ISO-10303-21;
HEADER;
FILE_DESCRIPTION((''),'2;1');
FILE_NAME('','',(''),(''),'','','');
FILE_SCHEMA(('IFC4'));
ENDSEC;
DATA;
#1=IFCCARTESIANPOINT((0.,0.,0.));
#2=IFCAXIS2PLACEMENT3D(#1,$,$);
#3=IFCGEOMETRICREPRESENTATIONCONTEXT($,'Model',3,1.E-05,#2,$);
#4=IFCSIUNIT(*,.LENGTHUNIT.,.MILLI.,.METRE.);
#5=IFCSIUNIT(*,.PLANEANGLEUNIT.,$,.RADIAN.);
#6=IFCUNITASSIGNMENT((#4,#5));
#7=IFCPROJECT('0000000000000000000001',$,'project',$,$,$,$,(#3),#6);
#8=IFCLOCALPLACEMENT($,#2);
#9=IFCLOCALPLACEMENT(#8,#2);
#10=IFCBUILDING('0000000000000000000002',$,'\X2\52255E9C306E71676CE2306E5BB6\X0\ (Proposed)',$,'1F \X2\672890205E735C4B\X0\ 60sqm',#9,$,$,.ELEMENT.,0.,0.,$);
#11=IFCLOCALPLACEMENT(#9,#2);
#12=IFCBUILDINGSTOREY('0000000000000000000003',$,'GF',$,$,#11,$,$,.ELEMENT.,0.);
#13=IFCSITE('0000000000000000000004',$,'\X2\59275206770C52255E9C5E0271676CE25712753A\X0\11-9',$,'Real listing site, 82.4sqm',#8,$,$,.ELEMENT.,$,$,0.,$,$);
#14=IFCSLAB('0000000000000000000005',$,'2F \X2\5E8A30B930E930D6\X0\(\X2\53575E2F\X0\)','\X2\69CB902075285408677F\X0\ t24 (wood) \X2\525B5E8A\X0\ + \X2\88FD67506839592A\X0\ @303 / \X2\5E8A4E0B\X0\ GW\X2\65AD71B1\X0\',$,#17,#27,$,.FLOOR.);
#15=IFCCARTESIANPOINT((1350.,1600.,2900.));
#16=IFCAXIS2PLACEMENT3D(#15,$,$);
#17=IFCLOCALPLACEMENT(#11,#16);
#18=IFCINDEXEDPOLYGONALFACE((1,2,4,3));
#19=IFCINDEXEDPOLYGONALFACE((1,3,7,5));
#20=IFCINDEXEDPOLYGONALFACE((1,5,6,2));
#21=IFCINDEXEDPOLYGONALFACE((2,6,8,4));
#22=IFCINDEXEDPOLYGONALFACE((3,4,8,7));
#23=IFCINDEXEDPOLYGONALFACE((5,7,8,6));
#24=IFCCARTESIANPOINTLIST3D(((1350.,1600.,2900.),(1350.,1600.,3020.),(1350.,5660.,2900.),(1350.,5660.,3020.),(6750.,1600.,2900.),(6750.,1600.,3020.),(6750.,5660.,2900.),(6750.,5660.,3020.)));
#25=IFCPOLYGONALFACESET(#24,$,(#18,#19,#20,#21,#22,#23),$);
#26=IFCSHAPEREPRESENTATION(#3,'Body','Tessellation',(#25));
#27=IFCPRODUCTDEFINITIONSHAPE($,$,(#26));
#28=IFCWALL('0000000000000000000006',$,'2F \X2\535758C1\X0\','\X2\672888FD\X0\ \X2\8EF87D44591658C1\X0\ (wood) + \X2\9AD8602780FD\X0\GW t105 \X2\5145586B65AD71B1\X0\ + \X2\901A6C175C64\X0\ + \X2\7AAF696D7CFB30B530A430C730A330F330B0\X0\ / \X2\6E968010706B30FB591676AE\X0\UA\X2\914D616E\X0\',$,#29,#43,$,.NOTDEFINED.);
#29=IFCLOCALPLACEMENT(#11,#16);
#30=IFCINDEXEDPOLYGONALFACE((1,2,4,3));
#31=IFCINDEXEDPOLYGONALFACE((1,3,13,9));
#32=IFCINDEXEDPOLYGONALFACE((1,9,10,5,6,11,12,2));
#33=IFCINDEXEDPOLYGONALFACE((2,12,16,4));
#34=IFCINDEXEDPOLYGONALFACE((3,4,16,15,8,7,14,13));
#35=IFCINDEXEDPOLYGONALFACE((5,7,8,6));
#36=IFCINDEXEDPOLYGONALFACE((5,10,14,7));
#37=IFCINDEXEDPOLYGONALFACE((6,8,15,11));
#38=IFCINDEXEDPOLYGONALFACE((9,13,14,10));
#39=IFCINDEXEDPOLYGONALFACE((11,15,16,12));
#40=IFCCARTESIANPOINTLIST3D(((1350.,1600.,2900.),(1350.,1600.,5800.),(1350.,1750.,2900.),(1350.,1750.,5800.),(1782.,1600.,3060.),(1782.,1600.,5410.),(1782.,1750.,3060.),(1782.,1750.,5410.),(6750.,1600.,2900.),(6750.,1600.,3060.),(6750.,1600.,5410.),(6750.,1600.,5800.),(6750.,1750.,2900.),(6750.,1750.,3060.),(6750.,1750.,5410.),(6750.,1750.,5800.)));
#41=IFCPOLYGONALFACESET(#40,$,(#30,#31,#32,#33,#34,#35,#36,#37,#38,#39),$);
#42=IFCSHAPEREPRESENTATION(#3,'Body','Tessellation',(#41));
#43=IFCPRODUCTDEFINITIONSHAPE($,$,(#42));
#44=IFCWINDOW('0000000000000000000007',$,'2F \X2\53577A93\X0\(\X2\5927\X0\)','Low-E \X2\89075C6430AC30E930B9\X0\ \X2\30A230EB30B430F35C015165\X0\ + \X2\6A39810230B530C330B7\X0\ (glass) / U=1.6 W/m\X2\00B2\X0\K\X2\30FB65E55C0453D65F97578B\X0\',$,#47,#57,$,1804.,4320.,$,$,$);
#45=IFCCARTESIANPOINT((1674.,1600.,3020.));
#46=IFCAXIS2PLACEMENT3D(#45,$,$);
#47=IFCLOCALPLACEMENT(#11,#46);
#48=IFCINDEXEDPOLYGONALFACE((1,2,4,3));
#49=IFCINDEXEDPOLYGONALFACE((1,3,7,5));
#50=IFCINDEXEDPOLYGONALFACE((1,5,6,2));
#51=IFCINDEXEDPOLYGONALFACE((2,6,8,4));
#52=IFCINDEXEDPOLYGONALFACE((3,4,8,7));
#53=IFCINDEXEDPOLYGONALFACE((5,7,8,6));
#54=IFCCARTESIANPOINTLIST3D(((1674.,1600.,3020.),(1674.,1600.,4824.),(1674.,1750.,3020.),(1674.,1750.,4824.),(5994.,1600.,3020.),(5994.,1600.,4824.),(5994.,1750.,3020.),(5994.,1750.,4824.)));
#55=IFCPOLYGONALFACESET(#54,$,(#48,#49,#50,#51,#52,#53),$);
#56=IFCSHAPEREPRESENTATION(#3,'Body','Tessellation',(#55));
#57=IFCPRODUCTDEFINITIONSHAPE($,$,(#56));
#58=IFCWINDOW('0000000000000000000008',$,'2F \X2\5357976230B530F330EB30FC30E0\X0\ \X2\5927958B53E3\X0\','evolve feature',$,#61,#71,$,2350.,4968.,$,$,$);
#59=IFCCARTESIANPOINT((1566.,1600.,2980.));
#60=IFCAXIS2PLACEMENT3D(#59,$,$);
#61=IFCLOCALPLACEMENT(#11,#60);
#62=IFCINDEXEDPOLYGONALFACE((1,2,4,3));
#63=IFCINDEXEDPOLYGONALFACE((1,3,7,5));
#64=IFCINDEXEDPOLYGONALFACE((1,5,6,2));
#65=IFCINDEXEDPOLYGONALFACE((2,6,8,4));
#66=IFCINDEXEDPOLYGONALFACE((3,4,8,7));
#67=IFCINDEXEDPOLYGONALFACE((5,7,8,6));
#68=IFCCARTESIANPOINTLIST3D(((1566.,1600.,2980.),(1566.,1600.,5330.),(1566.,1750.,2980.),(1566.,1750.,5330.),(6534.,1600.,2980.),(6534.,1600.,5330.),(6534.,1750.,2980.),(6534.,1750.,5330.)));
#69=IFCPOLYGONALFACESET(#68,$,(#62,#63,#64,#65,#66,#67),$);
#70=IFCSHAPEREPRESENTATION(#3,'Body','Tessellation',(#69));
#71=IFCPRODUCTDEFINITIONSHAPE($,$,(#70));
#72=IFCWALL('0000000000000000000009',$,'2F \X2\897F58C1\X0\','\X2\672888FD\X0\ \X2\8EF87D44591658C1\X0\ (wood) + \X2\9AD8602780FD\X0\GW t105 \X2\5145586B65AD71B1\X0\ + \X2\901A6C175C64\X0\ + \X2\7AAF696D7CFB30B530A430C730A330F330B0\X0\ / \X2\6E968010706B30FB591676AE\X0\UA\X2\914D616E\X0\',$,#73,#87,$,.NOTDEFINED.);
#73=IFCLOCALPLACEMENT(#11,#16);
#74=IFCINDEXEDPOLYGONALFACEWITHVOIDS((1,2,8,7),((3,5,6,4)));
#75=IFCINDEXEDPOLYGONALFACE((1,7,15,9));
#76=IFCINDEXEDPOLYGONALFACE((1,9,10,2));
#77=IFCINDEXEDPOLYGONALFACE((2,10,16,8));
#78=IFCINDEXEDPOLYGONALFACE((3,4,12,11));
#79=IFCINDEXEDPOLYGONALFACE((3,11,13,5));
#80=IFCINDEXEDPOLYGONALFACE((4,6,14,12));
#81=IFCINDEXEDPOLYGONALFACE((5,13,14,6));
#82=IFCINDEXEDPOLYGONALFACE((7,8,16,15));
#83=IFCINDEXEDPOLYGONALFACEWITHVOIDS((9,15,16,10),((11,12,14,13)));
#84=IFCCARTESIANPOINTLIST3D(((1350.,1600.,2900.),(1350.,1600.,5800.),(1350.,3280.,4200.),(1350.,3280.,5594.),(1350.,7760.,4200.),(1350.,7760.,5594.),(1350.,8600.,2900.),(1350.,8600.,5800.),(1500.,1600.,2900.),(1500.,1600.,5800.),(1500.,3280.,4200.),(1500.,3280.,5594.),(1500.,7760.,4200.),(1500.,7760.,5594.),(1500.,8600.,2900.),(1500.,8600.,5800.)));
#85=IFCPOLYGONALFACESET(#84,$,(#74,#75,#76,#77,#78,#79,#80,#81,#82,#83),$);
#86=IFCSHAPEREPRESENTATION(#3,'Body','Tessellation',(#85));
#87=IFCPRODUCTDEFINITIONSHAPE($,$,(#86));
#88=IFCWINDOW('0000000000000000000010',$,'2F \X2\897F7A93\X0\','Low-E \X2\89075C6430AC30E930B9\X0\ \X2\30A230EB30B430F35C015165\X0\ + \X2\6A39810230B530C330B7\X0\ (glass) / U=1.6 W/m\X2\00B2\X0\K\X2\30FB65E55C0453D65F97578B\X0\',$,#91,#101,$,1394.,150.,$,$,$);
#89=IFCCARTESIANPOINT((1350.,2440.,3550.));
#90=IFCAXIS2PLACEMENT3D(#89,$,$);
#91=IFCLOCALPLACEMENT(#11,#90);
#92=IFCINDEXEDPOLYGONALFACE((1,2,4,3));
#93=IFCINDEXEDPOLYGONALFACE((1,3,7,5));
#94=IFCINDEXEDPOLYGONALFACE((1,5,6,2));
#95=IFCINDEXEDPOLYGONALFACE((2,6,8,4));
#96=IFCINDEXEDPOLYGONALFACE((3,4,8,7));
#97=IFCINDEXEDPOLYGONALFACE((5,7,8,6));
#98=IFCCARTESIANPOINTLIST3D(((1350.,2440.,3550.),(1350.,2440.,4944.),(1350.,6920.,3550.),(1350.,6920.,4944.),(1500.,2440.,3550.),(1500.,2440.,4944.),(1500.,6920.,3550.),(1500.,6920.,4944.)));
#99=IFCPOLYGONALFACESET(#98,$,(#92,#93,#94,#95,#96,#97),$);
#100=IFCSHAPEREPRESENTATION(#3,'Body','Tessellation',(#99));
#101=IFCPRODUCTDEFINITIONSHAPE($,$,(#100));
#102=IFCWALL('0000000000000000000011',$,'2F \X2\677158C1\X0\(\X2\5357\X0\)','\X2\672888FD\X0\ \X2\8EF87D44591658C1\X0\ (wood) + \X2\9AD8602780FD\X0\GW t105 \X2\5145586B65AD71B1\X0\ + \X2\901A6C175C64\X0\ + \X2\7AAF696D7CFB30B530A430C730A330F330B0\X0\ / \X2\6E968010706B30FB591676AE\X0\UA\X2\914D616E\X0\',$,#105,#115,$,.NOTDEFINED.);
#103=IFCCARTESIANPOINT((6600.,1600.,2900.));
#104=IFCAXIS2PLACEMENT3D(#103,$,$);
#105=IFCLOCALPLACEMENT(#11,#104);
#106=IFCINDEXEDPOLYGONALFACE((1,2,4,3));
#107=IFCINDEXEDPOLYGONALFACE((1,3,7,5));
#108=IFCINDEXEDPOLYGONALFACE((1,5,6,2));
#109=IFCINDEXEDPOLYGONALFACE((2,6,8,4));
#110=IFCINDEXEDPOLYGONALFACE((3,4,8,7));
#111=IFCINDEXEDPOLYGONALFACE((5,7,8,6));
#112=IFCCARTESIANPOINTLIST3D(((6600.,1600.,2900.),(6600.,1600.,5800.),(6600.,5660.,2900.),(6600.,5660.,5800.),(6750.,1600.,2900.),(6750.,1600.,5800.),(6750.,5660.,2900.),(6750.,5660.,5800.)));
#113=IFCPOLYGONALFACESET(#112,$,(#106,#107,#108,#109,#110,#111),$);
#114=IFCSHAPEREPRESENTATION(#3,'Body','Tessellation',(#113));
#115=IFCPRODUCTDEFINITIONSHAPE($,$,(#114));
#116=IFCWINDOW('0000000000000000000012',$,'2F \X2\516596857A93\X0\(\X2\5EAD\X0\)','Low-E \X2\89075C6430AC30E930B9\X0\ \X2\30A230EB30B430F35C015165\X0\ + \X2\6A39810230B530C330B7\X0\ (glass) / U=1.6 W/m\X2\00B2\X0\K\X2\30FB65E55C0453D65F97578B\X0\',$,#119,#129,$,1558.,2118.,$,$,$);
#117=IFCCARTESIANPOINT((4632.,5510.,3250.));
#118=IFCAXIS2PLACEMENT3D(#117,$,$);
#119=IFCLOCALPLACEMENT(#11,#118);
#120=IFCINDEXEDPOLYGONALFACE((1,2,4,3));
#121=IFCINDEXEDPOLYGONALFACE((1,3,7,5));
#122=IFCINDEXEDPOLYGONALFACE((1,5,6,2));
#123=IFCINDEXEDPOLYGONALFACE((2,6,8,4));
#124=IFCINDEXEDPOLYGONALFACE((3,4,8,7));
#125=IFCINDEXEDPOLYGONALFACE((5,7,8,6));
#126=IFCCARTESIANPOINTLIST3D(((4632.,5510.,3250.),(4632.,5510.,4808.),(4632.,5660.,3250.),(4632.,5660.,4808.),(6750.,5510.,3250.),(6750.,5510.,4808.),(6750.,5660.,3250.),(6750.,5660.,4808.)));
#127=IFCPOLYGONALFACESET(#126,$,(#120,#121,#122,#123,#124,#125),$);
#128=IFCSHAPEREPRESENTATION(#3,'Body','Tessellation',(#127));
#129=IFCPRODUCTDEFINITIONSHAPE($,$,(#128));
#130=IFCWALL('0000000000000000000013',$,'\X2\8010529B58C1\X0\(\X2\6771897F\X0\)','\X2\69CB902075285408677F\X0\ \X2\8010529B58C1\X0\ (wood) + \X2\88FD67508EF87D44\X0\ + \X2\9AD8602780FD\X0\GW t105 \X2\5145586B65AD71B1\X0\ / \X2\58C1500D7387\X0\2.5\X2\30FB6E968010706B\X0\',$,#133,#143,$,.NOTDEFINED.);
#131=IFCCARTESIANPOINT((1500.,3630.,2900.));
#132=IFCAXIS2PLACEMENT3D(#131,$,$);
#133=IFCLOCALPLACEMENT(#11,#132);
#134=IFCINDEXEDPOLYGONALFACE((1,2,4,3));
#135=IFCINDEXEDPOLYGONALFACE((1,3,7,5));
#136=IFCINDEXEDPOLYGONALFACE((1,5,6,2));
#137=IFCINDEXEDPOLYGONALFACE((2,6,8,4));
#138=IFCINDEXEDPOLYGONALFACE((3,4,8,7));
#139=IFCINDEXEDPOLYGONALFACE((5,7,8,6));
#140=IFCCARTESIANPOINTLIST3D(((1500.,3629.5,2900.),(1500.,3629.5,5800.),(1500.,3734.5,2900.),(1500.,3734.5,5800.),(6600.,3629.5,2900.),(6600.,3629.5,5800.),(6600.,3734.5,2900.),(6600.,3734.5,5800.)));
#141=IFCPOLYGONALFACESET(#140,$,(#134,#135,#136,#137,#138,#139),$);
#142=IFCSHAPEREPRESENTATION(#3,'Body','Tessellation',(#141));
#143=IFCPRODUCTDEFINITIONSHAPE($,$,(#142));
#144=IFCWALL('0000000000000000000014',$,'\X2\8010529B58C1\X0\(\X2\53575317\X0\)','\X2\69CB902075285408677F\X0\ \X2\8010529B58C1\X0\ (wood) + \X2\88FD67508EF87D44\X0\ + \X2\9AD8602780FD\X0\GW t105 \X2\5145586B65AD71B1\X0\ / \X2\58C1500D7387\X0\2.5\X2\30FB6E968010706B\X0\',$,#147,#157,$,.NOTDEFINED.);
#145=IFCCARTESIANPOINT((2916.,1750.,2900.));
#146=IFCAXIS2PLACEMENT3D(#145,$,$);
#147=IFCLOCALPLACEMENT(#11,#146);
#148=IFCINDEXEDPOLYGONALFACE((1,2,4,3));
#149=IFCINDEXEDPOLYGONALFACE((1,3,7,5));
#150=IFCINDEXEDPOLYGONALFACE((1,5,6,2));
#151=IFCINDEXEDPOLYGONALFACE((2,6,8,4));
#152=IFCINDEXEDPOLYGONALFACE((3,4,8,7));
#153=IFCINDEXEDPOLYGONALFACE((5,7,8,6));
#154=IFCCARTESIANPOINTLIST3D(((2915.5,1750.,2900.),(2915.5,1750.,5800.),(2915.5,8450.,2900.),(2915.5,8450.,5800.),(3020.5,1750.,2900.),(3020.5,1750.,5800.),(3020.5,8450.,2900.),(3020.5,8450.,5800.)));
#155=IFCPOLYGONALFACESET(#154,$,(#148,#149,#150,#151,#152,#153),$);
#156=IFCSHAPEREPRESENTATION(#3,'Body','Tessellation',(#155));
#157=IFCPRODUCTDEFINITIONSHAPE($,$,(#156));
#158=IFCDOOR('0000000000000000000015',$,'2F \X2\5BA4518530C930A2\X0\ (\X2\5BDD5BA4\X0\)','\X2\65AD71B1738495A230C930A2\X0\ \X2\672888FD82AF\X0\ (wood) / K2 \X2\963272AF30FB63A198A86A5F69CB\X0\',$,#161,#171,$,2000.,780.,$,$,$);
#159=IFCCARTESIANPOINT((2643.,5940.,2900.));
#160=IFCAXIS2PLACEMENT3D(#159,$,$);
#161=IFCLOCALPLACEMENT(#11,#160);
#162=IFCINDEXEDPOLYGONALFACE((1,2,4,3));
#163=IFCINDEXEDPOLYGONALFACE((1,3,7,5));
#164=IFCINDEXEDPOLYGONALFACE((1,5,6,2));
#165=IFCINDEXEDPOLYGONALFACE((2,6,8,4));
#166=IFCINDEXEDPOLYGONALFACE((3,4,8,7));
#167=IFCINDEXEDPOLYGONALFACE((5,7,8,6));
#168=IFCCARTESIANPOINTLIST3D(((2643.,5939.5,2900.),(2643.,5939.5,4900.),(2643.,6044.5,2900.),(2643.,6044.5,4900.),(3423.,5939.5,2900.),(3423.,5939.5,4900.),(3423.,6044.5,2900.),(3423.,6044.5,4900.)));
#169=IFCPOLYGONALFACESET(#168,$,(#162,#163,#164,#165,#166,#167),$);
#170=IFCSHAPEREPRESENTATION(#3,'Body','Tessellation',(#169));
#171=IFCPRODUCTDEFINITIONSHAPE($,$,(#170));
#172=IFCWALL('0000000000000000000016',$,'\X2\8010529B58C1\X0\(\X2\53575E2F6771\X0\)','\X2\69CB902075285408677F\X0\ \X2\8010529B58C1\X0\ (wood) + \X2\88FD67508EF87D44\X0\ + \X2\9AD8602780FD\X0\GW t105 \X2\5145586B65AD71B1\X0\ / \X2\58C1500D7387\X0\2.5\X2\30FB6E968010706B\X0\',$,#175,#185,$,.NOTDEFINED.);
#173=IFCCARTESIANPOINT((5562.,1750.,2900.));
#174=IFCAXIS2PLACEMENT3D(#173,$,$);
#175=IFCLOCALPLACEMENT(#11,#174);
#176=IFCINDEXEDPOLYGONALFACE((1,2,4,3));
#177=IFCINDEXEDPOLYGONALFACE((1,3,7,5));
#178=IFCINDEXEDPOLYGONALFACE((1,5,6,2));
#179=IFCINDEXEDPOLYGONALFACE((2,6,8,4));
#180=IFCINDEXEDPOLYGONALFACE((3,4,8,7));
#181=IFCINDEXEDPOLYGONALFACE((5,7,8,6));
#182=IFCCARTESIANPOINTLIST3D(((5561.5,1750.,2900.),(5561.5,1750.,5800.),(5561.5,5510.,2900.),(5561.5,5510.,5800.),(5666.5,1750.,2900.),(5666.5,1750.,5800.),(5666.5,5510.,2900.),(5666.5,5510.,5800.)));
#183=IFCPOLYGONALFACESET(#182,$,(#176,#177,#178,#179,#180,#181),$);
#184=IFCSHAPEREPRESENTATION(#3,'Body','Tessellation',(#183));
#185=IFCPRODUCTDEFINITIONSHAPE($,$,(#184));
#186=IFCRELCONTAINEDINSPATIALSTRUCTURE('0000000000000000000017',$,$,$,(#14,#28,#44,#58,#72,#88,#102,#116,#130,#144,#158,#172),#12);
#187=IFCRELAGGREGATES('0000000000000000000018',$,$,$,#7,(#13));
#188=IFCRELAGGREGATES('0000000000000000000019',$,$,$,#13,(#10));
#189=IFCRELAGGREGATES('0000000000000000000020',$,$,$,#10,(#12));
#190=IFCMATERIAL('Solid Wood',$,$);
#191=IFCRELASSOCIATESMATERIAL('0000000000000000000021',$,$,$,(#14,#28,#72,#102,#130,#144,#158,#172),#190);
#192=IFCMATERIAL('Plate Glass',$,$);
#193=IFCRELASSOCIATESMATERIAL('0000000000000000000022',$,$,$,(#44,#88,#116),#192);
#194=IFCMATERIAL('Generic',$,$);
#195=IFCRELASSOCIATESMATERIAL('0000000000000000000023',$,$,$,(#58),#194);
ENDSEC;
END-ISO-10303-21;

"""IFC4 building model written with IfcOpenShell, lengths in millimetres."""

from ifc_helpers import new_model, si_unit, frame, frame_2d, origin, place, context, project, spatial, rectangle, extrude, material, element, fill, save


model = new_model("IFC4")

# Units and contexts
model_context = context("Model", 3, precision=1e-05, world=origin())
ifc_project = project(units=[si_unit("LENGTHUNIT", "METRE", prefix="MILLI"), si_unit("PLANEANGLEUNIT", "RADIAN")], contexts=[model_context])

# Site, building, storey
site_placement = place(None, origin())
site = spatial("IfcSite", under=ifc_project, at=site_placement, Name="大分県別府市照波園町11-9", ObjectType="Real listing site, 82.4sqm", CompositionType="ELEMENT", RefElevation=0.0)
building_placement = place(site_placement, origin())
building = spatial("IfcBuilding", under=site, at=building_placement, Name="別府の照波の家 (Proposed)", ObjectType="1F 木造平屋 60sqm", CompositionType="ELEMENT", ElevationOfRefHeight=0.0, ElevationOfTerrain=0.0)
storey_placement = place(building_placement, origin())
storey = spatial("IfcBuildingStorey", under=building, at=storey_placement, Name="GF", CompositionType="ELEMENT", Elevation=0.0)

# Slab
ifc_material_1 = material(Name="Solid Wood")
slab_placement = place(storey_placement, frame((1350.0, 1600.0, 2900.0)))
element("IfcSlab", 1, at=slab_placement, inside=storey, material=ifc_material_1, Name="2F 床スラブ(南帯)", Description="構造用合板 t24 (wood) 剛床 + 製材根太 @303 / 床下 GW断熱", PredefinedType="FLOOR", context=model_context, shape_type="SweptSolid", body=[
    extrude(rectangle(XDim=5400.0, YDim=4060.0, at=frame_2d((2700.0, 2030.0))), frame((1350.0, 1600.0, 2900.0)), (0.0, 0.0, 1.0), 120.0),
])

# Wall, openings, windows
wall_1_placement = place(storey_placement, frame((1350.0, 1600.0, 2900.0)))
wall_1 = element("IfcWall", 2, at=wall_1_placement, inside=storey, material=ifc_material_1, Name="2F 南壁", Description="木製 軸組外壁 (wood) + 高性能GW t105 充填断熱 + 通気層 + 窯業系サイディング / 準耐火・外皮UA配慮", PredefinedType="NOTDEFINED", context=model_context, shape_type="SweptSolid", body=[
    extrude(rectangle(XDim=5400.0, YDim=150.0, at=frame_2d((2700.0, 75.0))), frame((1350.0, 1600.0, 2900.0)), (0.0, 0.0, 1.0), 2900.0),
])
opening_1_placement = place(storey_placement, frame((1674.0, 1600.0, 3020.0)))
opening_1 = element("IfcOpeningElement", 3, at=opening_1_placement, cuts=wall_1, PredefinedType="NOTDEFINED", context=model_context, shape_type="SweptSolid", body=[
    extrude(rectangle(XDim=4320.0, YDim=150.0, at=frame_2d((2160.0, 75.0))), frame((1674.0, 1600.0, 3020.0)), (0.0, 0.0, 1.0), 1804.0),
])
opening_2_placement = place(storey_placement, frame((1566.0, 1600.0, 2980.0)))
opening_2 = element("IfcOpeningElement", 4, at=opening_2_placement, cuts=wall_1, PredefinedType="NOTDEFINED", context=model_context, shape_type="SweptSolid", body=[
    extrude(rectangle(XDim=4968.0, YDim=150.0, at=frame_2d((2484.0, 75.0))), frame((1566.0, 1600.0, 2980.0)), (0.0, 0.0, 1.0), 2350.0),
])
ifc_material_2 = material(Name="Plate Glass")
window_1_placement = place(storey_placement, frame((1674.0, 1600.0, 3020.0)))
window_1 = element("IfcWindow", 5, at=window_1_placement, inside=storey, material=ifc_material_2, Name="2F 南窓(大)", Description="Low-E 複層ガラス アルゴン封入 + 樹脂サッシ (glass) / U=1.6 W/m²K・日射取得型", OverallHeight=1804.0, OverallWidth=4320.0, context=model_context, shape_type="SweptSolid", body=[
    extrude(rectangle(XDim=4320.0, YDim=150.0, at=frame_2d((2160.0, 75.0))), frame((1674.0, 1600.0, 3020.0)), (0.0, 0.0, 1.0), 1804.0),
])
fill(opening_1, window_1)
ifc_material_3 = material(Name="Generic")
window_2_placement = place(storey_placement, frame((1566.0, 1600.0, 2980.0)))
window_2 = element("IfcWindow", 6, at=window_2_placement, inside=storey, material=ifc_material_3, Name="2F 南面サンルーム 大開口", Description="evolve feature", OverallHeight=2350.0, OverallWidth=4968.0, context=model_context, shape_type="SweptSolid", body=[
    extrude(rectangle(XDim=4968.0, YDim=150.0, at=frame_2d((2484.0, 75.0))), frame((1566.0, 1600.0, 2980.0)), (0.0, 0.0, 1.0), 2350.0),
])
fill(opening_2, window_2)

# Walls, openings, windows
wall_2_placement = place(storey_placement, frame((1350.0, 1600.0, 2900.0)))
wall_2 = element("IfcWall", 7, at=wall_2_placement, inside=storey, material=ifc_material_1, Name="2F 西壁", Description="木製 軸組外壁 (wood) + 高性能GW t105 充填断熱 + 通気層 + 窯業系サイディング / 準耐火・外皮UA配慮", PredefinedType="NOTDEFINED", context=model_context, shape_type="SweptSolid", body=[
    extrude(rectangle(XDim=150.0, YDim=7000.0, at=frame_2d((75.0, 3500.0))), frame((1350.0, 1600.0, 2900.0)), (0.0, 0.0, 1.0), 2900.0),
])
opening_3_placement = place(storey_placement, frame((1350.0, 2440.0, 3550.0)))
opening_3 = element("IfcOpeningElement", 8, at=opening_3_placement, cuts=wall_2, PredefinedType="NOTDEFINED", context=model_context, shape_type="SweptSolid", body=[
    extrude(rectangle(XDim=150.0, YDim=4480.0, at=frame_2d((75.0, 2240.0))), frame((1350.0, 2440.0, 3550.0)), (0.0, 0.0, 1.0), 1394.0),
])
window_3_placement = place(storey_placement, frame((1350.0, 2440.0, 3550.0)))
window_3 = element("IfcWindow", 9, at=window_3_placement, inside=storey, material=ifc_material_2, Name="2F 西窓", Description="Low-E 複層ガラス アルゴン封入 + 樹脂サッシ (glass) / U=1.6 W/m²K・日射取得型", OverallHeight=1394.0, OverallWidth=150.0, context=model_context, shape_type="SweptSolid", body=[
    extrude(rectangle(XDim=150.0, YDim=4480.0, at=frame_2d((75.0, 2240.0))), frame((1350.0, 2440.0, 3550.0)), (0.0, 0.0, 1.0), 1394.0),
])
fill(opening_3, window_3)
wall_3_placement = place(storey_placement, frame((6600.0, 1600.0, 2900.0)))
wall_3 = element("IfcWall", 10, at=wall_3_placement, inside=storey, material=ifc_material_1, Name="2F 東壁(南)", Description="木製 軸組外壁 (wood) + 高性能GW t105 充填断熱 + 通気層 + 窯業系サイディング / 準耐火・外皮UA配慮", PredefinedType="NOTDEFINED", context=model_context, shape_type="SweptSolid", body=[
    extrude(rectangle(XDim=150.0, YDim=4060.0, at=frame_2d((75.0, 2030.0))), frame((6600.0, 1600.0, 2900.0)), (0.0, 0.0, 1.0), 2900.0),
])
opening_4_placement = place(storey_placement, frame((4632.0, 5510.0, 3250.0)))
opening_4 = element("IfcOpeningElement", 11, at=opening_4_placement, cuts=wall_3, PredefinedType="NOTDEFINED", context=model_context, shape_type="SweptSolid", body=[
    extrude(rectangle(XDim=2118.0, YDim=150.0, at=frame_2d((1059.0, 75.0))), frame((4632.0, 5510.0, 3250.0)), (0.0, 0.0, 1.0), 1558.0),
])
window_4_placement = place(storey_placement, frame((4632.0, 5510.0, 3250.0)))
window_4 = element("IfcWindow", 12, at=window_4_placement, inside=storey, material=ifc_material_2, Name="2F 入隅窓(庭)", Description="Low-E 複層ガラス アルゴン封入 + 樹脂サッシ (glass) / U=1.6 W/m²K・日射取得型", OverallHeight=1558.0, OverallWidth=2118.0, context=model_context, shape_type="SweptSolid", body=[
    extrude(rectangle(XDim=2118.0, YDim=150.0, at=frame_2d((1059.0, 75.0))), frame((4632.0, 5510.0, 3250.0)), (0.0, 0.0, 1.0), 1558.0),
])
fill(opening_4, window_4)

# Wall
wall_4_placement = place(storey_placement, frame((1500.0, 3630.0, 2900.0)))
element("IfcWall", 13, at=wall_4_placement, inside=storey, material=ifc_material_1, Name="耐力壁(東西)", Description="構造用合板 耐力壁 (wood) + 製材軸組 + 高性能GW t105 充填断熱 / 壁倍率2.5・準耐火", PredefinedType="NOTDEFINED", context=model_context, shape_type="SweptSolid", body=[
    extrude(rectangle(XDim=5100.0, YDim=105.0, at=frame_2d((2550.0, 52.0))), frame((1500.0, 3630.0, 2900.0)), (0.0, 0.0, 1.0), 2900.0),
])

# Wall, opening, door
wall_5_placement = place(storey_placement, frame((2916.0, 1750.0, 2900.0)))
wall_5 = element("IfcWall", 14, at=wall_5_placement, inside=storey, material=ifc_material_1, Name="耐力壁(南北)", Description="構造用合板 耐力壁 (wood) + 製材軸組 + 高性能GW t105 充填断熱 / 壁倍率2.5・準耐火", PredefinedType="NOTDEFINED", context=model_context, shape_type="SweptSolid", body=[
    extrude(rectangle(XDim=105.0, YDim=6700.0, at=frame_2d((52.0, 3350.0))), frame((2916.0, 1750.0, 2900.0)), (0.0, 0.0, 1.0), 2900.0),
])
opening_5_placement = place(storey_placement, frame((2643.0, 5940.0, 2900.0)))
opening_5 = element("IfcOpeningElement", 15, at=opening_5_placement, cuts=wall_5, PredefinedType="NOTDEFINED", context=model_context, shape_type="SweptSolid", body=[
    extrude(rectangle(XDim=780.0, YDim=105.0, at=frame_2d((390.0, 52.0))), frame((2643.0, 5940.0, 2900.0)), (0.0, 0.0, 1.0), 2000.0),
])
door_placement = place(storey_placement, frame((2643.0, 5940.0, 2900.0)))
door = element("IfcDoor", 16, at=door_placement, inside=storey, material=ifc_material_1, Name="2F 室内ドア (寝室)", Description="断熱玄関ドア 木製芯 (wood) / K2 防犯・採風機構", OverallHeight=2000.0, OverallWidth=780.0, context=model_context, shape_type="SweptSolid", body=[
    extrude(rectangle(XDim=780.0, YDim=105.0, at=frame_2d((390.0, 52.0))), frame((2643.0, 5940.0, 2900.0)), (0.0, 0.0, 1.0), 2000.0),
])
fill(opening_5, door)

# Wall
wall_6_placement = place(storey_placement, frame((5562.0, 1750.0, 2900.0)))
element("IfcWall", 17, at=wall_6_placement, inside=storey, material=ifc_material_1, Name="耐力壁(南帯東)", Description="構造用合板 耐力壁 (wood) + 製材軸組 + 高性能GW t105 充填断熱 / 壁倍率2.5・準耐火", PredefinedType="NOTDEFINED", context=model_context, shape_type="SweptSolid", body=[
    extrude(rectangle(XDim=105.0, YDim=3760.0, at=frame_2d((52.0, 1880.0))), frame((5562.0, 1750.0, 2900.0)), (0.0, 0.0, 1.0), 2900.0),
])

save(model, "model.ifc")
